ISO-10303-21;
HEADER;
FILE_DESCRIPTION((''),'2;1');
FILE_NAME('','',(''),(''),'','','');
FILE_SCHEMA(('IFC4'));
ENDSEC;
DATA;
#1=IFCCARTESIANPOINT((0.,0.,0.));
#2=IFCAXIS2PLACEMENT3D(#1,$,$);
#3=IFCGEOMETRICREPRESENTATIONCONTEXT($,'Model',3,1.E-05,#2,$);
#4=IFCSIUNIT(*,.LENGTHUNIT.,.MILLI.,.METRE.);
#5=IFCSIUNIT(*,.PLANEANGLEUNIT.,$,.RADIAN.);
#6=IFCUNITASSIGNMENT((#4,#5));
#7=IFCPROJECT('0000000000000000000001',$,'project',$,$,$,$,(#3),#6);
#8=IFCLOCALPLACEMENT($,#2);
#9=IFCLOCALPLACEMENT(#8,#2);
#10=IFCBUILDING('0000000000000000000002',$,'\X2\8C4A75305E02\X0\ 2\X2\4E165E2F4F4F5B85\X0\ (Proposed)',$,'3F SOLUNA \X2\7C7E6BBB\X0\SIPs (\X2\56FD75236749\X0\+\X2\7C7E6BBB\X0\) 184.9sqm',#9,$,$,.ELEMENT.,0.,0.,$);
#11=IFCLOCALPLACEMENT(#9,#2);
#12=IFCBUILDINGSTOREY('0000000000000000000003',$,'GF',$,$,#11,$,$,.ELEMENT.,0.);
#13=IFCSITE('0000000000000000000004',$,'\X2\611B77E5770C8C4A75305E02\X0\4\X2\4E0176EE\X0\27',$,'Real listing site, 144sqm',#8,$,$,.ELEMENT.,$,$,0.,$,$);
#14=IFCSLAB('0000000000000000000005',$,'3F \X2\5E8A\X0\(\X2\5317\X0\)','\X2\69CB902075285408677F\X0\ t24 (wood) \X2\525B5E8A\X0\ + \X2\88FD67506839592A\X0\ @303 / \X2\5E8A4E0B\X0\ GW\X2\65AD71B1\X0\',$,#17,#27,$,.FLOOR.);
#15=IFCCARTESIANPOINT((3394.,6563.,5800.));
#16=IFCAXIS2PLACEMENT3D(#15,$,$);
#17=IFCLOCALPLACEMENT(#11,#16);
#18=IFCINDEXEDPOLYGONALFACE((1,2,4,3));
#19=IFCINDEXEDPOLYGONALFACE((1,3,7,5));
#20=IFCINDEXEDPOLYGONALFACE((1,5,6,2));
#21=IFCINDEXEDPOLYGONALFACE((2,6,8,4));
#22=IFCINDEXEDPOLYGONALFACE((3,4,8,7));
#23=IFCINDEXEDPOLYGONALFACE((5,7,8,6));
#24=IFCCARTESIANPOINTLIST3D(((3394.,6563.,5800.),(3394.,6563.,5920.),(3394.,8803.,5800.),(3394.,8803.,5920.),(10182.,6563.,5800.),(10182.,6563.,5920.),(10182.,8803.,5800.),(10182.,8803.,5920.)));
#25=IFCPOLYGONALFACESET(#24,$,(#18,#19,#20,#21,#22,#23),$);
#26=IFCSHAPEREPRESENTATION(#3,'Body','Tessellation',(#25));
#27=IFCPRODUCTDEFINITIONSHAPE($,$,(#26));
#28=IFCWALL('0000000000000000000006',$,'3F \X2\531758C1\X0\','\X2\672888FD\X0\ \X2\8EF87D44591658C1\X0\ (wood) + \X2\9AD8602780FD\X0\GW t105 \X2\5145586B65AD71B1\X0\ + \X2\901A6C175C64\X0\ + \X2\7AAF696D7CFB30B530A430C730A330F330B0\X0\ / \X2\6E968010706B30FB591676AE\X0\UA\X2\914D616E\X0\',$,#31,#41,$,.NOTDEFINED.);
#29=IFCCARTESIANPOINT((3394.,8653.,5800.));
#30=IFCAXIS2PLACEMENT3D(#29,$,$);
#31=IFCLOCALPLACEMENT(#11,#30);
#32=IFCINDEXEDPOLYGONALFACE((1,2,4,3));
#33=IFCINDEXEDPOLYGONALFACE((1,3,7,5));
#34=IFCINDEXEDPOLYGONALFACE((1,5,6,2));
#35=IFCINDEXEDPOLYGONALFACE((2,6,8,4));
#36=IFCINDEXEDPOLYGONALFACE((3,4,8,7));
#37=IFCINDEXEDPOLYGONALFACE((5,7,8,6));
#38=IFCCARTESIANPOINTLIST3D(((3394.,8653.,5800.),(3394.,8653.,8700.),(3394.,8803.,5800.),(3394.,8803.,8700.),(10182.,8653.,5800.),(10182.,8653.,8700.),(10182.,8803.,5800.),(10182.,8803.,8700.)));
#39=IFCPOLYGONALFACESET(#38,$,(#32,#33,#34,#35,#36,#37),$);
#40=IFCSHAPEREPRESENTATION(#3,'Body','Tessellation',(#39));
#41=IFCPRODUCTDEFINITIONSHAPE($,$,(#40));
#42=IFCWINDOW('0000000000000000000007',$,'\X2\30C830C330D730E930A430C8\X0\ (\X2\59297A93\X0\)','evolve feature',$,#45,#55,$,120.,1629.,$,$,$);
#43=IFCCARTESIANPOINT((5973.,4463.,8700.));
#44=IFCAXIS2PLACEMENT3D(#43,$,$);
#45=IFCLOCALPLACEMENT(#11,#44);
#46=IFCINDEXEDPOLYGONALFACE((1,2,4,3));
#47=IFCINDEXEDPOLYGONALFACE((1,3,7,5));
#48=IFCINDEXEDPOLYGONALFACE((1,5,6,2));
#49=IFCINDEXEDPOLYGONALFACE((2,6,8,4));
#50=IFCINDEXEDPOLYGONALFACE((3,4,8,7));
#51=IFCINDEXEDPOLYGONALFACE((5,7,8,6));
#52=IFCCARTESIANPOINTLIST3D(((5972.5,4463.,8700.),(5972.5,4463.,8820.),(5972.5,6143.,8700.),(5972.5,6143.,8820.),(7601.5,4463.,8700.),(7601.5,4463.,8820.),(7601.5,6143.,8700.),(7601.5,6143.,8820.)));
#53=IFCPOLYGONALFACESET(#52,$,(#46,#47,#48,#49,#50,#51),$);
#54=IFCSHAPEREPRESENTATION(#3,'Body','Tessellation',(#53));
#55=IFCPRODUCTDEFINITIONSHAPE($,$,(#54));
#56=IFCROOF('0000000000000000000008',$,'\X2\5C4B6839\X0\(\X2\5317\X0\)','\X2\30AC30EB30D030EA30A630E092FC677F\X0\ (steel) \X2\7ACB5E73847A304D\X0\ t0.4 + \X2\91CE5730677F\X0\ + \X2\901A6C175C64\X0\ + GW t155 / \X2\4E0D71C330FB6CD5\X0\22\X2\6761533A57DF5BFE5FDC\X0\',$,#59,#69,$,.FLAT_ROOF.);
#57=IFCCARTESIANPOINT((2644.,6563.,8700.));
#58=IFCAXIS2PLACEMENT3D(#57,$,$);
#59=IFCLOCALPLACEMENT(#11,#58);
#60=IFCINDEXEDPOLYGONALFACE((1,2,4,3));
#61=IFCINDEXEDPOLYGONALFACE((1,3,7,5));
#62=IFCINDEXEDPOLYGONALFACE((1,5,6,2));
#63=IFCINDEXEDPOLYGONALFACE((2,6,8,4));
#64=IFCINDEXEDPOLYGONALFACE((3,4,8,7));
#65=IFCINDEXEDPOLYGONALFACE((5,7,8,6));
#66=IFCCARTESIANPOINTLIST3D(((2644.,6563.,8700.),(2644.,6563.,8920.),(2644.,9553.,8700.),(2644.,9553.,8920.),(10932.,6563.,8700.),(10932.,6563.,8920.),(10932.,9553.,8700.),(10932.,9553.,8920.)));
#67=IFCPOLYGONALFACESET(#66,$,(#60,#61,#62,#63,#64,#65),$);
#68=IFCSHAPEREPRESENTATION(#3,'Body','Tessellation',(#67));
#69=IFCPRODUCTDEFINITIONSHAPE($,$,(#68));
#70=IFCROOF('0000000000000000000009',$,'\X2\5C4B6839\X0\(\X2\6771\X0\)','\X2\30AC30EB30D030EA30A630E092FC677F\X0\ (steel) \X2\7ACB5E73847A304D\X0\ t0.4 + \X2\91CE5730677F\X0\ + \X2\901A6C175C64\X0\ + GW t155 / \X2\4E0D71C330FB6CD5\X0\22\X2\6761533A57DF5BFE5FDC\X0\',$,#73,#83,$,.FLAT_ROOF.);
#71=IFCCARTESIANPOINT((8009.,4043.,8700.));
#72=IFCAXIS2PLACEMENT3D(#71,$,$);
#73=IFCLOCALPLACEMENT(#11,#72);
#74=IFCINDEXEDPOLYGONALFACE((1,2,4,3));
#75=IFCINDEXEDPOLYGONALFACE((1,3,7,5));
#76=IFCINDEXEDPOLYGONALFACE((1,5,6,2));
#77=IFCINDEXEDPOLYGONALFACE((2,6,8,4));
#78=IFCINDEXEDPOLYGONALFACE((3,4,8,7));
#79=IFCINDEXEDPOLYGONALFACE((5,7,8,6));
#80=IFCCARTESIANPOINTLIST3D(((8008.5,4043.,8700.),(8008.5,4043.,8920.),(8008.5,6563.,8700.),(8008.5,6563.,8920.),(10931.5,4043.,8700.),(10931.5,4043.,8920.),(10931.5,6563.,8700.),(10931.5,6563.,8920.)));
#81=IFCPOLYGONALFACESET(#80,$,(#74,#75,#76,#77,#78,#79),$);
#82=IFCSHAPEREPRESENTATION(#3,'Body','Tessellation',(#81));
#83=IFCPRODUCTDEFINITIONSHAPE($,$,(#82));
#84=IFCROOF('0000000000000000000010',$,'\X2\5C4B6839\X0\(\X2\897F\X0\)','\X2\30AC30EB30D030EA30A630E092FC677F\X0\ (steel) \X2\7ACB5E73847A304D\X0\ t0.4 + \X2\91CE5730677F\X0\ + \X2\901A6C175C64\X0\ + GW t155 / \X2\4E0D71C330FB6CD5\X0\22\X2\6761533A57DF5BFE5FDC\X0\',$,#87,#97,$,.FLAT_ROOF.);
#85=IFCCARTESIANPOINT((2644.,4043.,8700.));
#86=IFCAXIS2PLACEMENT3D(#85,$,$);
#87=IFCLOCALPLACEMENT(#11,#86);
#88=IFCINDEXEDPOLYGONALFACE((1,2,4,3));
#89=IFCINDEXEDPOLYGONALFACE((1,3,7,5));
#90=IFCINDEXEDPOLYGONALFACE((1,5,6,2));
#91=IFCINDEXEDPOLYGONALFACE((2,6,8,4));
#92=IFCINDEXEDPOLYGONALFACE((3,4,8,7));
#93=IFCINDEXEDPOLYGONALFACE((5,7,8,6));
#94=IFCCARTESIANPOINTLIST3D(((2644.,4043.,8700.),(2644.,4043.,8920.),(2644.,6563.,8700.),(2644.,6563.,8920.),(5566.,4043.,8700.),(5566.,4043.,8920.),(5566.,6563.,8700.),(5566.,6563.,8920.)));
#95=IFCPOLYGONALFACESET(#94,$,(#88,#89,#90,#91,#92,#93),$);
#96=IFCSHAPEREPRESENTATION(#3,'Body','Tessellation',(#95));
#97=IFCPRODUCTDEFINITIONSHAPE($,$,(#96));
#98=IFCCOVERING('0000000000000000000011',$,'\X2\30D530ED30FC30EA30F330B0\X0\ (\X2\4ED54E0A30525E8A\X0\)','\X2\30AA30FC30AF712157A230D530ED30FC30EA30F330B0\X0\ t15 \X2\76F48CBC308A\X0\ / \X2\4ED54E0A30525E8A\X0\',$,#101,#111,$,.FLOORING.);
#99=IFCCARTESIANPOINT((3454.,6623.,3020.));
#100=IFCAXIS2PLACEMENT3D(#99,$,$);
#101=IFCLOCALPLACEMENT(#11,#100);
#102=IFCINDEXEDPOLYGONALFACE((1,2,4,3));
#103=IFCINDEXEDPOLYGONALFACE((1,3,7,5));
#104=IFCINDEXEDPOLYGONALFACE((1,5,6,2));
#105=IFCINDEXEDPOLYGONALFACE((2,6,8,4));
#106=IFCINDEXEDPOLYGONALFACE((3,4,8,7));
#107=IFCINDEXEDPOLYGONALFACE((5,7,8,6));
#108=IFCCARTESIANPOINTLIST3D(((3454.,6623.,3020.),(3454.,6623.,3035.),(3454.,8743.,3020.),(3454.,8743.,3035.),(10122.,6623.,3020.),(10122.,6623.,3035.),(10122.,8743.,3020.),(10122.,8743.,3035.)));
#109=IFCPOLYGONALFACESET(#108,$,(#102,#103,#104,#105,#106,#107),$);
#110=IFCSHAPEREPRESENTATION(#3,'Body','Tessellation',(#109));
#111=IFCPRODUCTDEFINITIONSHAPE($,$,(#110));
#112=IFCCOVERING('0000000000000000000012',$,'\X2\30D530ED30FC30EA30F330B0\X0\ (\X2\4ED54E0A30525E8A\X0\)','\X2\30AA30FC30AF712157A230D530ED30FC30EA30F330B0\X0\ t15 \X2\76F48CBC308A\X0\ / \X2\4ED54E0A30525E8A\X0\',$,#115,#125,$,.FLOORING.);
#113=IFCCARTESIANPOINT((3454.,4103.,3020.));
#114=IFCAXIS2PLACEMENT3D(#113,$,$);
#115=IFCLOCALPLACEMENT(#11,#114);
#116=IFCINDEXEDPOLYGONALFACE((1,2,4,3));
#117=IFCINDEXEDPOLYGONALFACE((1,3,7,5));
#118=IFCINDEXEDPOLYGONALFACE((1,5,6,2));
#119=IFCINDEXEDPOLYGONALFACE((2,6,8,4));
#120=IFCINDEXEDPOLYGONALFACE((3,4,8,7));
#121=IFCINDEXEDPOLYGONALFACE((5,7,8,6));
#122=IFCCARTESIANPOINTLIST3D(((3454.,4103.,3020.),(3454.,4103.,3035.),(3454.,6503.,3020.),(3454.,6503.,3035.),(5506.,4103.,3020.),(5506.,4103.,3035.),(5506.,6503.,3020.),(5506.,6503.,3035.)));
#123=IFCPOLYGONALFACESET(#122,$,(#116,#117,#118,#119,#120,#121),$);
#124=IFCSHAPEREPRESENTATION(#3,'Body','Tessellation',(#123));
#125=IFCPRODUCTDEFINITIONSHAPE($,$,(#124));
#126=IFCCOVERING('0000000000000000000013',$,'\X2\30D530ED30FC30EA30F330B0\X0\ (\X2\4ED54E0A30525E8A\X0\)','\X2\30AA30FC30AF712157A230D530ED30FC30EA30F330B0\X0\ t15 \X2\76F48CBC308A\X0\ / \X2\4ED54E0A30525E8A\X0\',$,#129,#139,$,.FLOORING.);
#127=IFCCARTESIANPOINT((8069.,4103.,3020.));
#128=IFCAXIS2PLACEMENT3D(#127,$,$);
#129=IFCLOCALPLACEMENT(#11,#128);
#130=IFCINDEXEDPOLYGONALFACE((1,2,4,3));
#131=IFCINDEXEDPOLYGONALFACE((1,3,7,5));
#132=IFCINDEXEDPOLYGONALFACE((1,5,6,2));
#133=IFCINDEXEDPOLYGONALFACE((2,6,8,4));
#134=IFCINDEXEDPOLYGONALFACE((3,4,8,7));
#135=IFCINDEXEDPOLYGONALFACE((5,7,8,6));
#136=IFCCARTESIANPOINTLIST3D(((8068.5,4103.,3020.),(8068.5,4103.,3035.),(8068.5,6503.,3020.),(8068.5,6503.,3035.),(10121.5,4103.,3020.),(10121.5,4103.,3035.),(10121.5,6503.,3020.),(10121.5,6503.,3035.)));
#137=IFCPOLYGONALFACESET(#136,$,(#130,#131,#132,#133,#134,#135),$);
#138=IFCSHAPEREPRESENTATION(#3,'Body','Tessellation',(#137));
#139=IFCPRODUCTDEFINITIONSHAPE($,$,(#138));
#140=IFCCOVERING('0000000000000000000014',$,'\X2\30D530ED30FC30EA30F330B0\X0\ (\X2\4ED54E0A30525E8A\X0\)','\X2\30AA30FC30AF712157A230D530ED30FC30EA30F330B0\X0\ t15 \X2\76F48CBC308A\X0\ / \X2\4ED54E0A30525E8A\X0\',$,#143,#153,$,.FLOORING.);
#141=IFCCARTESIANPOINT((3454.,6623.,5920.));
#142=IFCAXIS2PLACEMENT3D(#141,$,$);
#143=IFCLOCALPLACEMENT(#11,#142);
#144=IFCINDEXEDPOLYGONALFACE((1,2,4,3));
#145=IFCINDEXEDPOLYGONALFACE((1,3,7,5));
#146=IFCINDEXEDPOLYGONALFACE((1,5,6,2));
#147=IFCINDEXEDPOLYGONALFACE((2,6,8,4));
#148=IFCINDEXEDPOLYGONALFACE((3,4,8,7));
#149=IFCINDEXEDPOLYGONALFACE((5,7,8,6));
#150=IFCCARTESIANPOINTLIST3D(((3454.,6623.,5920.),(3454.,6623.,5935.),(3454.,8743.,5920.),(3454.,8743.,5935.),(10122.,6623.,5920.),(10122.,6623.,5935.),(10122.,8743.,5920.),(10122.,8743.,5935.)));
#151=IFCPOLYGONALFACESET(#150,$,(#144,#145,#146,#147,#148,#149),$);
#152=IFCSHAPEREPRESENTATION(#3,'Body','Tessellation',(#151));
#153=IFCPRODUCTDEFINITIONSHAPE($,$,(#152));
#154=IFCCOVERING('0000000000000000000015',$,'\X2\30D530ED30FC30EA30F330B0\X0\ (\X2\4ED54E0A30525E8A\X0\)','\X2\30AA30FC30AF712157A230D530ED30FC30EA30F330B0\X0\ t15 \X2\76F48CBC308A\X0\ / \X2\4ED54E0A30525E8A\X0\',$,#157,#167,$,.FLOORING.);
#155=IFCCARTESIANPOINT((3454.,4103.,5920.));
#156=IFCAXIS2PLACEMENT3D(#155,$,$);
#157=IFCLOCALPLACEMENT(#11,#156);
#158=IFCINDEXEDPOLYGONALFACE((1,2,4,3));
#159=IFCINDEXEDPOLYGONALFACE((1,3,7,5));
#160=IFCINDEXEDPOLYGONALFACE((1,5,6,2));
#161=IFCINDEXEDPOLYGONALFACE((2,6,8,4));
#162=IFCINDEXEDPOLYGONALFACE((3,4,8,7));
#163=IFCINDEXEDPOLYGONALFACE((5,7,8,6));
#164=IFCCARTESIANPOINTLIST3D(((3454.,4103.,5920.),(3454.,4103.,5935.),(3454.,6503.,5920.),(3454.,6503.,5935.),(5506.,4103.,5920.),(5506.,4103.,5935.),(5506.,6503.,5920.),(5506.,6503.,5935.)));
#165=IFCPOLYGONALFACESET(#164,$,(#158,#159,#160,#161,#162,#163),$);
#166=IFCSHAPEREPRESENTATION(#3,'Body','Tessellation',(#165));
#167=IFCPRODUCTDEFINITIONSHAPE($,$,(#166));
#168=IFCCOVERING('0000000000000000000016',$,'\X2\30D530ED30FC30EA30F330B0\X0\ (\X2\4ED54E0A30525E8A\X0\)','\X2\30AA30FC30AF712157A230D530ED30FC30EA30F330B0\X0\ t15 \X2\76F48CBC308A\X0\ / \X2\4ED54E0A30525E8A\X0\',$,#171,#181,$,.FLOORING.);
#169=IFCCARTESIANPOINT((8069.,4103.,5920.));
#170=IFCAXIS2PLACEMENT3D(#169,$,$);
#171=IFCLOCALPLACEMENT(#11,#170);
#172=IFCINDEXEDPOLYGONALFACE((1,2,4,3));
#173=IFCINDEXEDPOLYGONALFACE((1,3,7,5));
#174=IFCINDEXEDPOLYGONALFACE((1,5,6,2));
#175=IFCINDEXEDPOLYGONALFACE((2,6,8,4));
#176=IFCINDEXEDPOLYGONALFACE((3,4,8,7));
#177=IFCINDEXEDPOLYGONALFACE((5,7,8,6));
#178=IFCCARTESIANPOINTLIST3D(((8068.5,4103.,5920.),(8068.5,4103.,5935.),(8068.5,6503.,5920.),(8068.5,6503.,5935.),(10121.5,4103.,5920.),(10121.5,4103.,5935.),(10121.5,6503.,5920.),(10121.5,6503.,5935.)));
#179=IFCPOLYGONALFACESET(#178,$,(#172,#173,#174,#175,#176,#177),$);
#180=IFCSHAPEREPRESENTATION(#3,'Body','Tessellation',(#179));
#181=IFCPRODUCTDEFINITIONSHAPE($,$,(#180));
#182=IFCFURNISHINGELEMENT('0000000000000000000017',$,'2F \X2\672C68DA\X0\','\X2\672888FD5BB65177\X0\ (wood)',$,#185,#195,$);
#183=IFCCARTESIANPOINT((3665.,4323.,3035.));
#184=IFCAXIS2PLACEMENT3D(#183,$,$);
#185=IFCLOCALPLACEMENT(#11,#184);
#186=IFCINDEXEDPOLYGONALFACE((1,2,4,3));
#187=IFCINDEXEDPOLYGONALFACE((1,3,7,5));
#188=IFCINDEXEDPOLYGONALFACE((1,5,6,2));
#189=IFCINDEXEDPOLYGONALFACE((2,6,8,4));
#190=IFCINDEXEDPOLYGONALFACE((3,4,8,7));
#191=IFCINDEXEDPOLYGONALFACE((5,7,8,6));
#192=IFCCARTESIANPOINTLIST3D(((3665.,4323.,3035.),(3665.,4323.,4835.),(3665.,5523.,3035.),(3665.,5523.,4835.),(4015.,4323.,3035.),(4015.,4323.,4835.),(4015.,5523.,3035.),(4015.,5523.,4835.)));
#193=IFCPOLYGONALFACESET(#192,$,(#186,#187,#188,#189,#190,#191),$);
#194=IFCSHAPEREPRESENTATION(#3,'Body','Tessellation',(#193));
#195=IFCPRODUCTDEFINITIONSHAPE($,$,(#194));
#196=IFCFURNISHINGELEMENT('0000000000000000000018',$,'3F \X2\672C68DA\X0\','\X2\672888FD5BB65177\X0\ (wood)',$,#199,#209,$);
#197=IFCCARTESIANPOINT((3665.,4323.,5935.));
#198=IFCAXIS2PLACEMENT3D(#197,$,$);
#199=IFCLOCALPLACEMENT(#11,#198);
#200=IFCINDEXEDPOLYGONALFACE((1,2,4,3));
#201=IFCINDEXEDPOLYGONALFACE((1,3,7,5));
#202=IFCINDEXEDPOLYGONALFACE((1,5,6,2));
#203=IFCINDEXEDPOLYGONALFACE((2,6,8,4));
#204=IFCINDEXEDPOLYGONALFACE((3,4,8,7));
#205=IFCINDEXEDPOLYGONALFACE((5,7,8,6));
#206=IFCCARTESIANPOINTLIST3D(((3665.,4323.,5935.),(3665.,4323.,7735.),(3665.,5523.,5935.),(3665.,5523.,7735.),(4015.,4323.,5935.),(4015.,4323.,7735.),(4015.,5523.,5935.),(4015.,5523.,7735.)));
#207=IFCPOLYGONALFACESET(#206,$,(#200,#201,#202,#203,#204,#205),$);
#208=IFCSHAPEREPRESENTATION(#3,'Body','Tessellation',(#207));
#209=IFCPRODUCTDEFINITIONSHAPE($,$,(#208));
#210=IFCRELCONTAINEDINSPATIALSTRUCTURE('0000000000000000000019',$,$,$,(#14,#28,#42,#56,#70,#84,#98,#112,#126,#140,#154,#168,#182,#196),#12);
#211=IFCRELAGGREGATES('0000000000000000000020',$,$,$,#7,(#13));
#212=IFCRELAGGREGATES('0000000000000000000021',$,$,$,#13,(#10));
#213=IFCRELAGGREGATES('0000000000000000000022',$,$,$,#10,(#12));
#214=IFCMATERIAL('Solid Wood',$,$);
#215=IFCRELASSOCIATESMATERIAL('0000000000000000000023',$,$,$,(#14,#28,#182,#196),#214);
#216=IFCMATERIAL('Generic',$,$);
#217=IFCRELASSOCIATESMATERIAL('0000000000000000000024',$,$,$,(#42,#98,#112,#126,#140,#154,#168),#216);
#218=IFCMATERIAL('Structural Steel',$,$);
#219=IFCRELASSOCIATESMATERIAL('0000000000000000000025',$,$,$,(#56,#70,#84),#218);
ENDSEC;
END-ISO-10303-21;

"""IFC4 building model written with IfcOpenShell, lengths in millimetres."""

from ifc_helpers import new_model, si_unit, frame, frame_2d, origin, place, context, project, spatial, rectangle, extrude, material, element, save


model = new_model("IFC4")

# Units and contexts
model_context = context("Model", 3, precision=1e-05, world=origin())
ifc_project = project(units=[si_unit("LENGTHUNIT", "METRE", prefix="MILLI"), si_unit("PLANEANGLEUNIT", "RADIAN")], contexts=[model_context])

# Site, building, storey
site_placement = place(None, origin())
site = spatial("IfcSite", under=ifc_project, at=site_placement, Name="愛知県豊田市4丁目27", ObjectType="Real listing site, 144sqm", CompositionType="ELEMENT", RefElevation=0.0)
building_placement = place(site_placement, origin())
building = spatial("IfcBuilding", under=site, at=building_placement, Name="豊田市 2世帯住宅 (Proposed)", ObjectType="3F SOLUNA 籾殻SIPs (国産杉+籾殻) 184.9sqm", CompositionType="ELEMENT", ElevationOfRefHeight=0.0, ElevationOfTerrain=0.0)
storey_placement = place(building_placement, origin())
storey = spatial("IfcBuildingStorey", under=building, at=storey_placement, Name="GF", CompositionType="ELEMENT", Elevation=0.0)

# Slab
ifc_material_1 = material(Name="Solid Wood")
slab_placement = place(storey_placement, frame((3394.0, 6563.0, 5800.0)))
element("IfcSlab", 1, at=slab_placement, inside=storey, material=ifc_material_1, Name="3F 床(北)", Description="構造用合板 t24 (wood) 剛床 + 製材根太 @303 / 床下 GW断熱", PredefinedType="FLOOR", context=model_context, shape_type="SweptSolid", body=[
    extrude(rectangle(XDim=6788.0, YDim=2240.0, at=frame_2d((3394.0, 1120.0))), frame((3394.0, 6563.0, 5800.0)), (0.0, 0.0, 1.0), 120.0),
])

# Wall
wall_1_placement = place(storey_placement, frame((3394.0, 8653.0, 5800.0)))
element("IfcWall", 2, at=wall_1_placement, inside=storey, material=ifc_material_1, Name="3F 北壁", Description="木製 軸組外壁 (wood) + 高性能GW t105 充填断熱 + 通気層 + 窯業系サイディング / 準耐火・外皮UA配慮", PredefinedType="NOTDEFINED", context=model_context, shape_type="SweptSolid", body=[
    extrude(rectangle(XDim=6788.0, YDim=150.0, at=frame_2d((3394.0, 75.0))), frame((3394.0, 8653.0, 5800.0)), (0.0, 0.0, 1.0), 2900.0),
])

# Window
ifc_material_2 = material(Name="Generic")
window_1_placement = place(storey_placement, frame((5973.0, 4463.0, 8700.0)))
element("IfcWindow", 3, at=window_1_placement, inside=storey, material=ifc_material_2, Name="トップライト (天窓)", Description="evolve feature", OverallHeight=120.0, OverallWidth=1629.0, context=model_context, shape_type="SweptSolid", body=[
    extrude(rectangle(XDim=1629.0, YDim=1680.0, at=frame_2d((814.0, 840.0))), frame((5973.0, 4463.0, 8700.0)), (0.0, 0.0, 1.0), 120.0),
])

# Roofs
ifc_material_3 = material(Name="Structural Steel")
roof_1_placement = place(storey_placement, frame((2644.0, 6563.0, 8700.0)))
element("IfcRoof", 4, at=roof_1_placement, inside=storey, material=ifc_material_3, Name="屋根(北)", Description="ガルバリウム鋼板 (steel) 立平葺き t0.4 + 野地板 + 通気層 + GW t155 / 不燃・法22条区域対応", PredefinedType="FLAT_ROOF", context=model_context, shape_type="SweptSolid", body=[
    extrude(rectangle(XDim=8288.0, YDim=2990.0, at=frame_2d((4144.0, 1495.0))), frame((2644.0, 6563.0, 8700.0)), (0.0, 0.0, 1.0), 220.0),
])
roof_2_placement = place(storey_placement, frame((8009.0, 4043.0, 8700.0)))
element("IfcRoof", 5, at=roof_2_placement, inside=storey, material=ifc_material_3, Name="屋根(東)", Description="ガルバリウム鋼板 (steel) 立平葺き t0.4 + 野地板 + 通気層 + GW t155 / 不燃・法22条区域対応", PredefinedType="FLAT_ROOF", context=model_context, shape_type="SweptSolid", body=[
    extrude(rectangle(XDim=2923.0, YDim=2520.0, at=frame_2d((1461.0, 1260.0))), frame((8009.0, 4043.0, 8700.0)), (0.0, 0.0, 1.0), 220.0),
])
roof_3_placement = place(storey_placement, frame((2644.0, 4043.0, 8700.0)))
element("IfcRoof", 6, at=roof_3_placement, inside=storey, material=ifc_material_3, Name="屋根(西)", Description="ガルバリウム鋼板 (steel) 立平葺き t0.4 + 野地板 + 通気層 + GW t155 / 不燃・法22条区域対応", PredefinedType="FLAT_ROOF", context=model_context, shape_type="SweptSolid", body=[
    extrude(rectangle(XDim=2922.0, YDim=2520.0, at=frame_2d((1461.0, 1260.0))), frame((2644.0, 4043.0, 8700.0)), (0.0, 0.0, 1.0), 220.0),
])

# Coverings
covering_1_placement = place(storey_placement, frame((3454.0, 6623.0, 3020.0)))
element("IfcCovering", 7, at=covering_1_placement, inside=storey, material=ifc_material_2, Name="フローリング (仕上げ床)", Description="オーク無垢フローリング t15 直貼り / 仕上げ床", PredefinedType="FLOORING", context=model_context, shape_type="SweptSolid", body=[
    extrude(rectangle(XDim=6668.0, YDim=2120.0, at=frame_2d((3334.0, 1060.0))), frame((3454.0, 6623.0, 3020.0)), (0.0, 0.0, 1.0), 15.0),
])
covering_2_placement = place(storey_placement, frame((3454.0, 4103.0, 3020.0)))
element("IfcCovering", 8, at=covering_2_placement, inside=storey, material=ifc_material_2, Name="フローリング (仕上げ床)", Description="オーク無垢フローリング t15 直貼り / 仕上げ床", PredefinedType="FLOORING", context=model_context, shape_type="SweptSolid", body=[
    extrude(rectangle(XDim=2052.0, YDim=2400.0, at=frame_2d((1026.0, 1200.0))), frame((3454.0, 4103.0, 3020.0)), (0.0, 0.0, 1.0), 15.0),
])
covering_3_placement = place(storey_placement, frame((8069.0, 4103.0, 3020.0)))
element("IfcCovering", 9, at=covering_3_placement, inside=storey, material=ifc_material_2, Name="フローリング (仕上げ床)", Description="オーク無垢フローリング t15 直貼り / 仕上げ床", PredefinedType="FLOORING", context=model_context, shape_type="SweptSolid", body=[
    extrude(rectangle(XDim=2053.0, YDim=2400.0, at=frame_2d((1026.0, 1200.0))), frame((8069.0, 4103.0, 3020.0)), (0.0, 0.0, 1.0), 15.0),
])
covering_4_placement = place(storey_placement, frame((3454.0, 6623.0, 5920.0)))
element("IfcCovering", 10, at=covering_4_placement, inside=storey, material=ifc_material_2, Name="フローリング (仕上げ床)", Description="オーク無垢フローリング t15 直貼り / 仕上げ床", PredefinedType="FLOORING", context=model_context, shape_type="SweptSolid", body=[
    extrude(rectangle(XDim=6668.0, YDim=2120.0, at=frame_2d((3334.0, 1060.0))), frame((3454.0, 6623.0, 5920.0)), (0.0, 0.0, 1.0), 15.0),
])
covering_5_placement = place(storey_placement, frame((3454.0, 4103.0, 5920.0)))
element("IfcCovering", 11, at=covering_5_placement, inside=storey, material=ifc_material_2, Name="フローリング (仕上げ床)", Description="オーク無垢フローリング t15 直貼り / 仕上げ床", PredefinedType="FLOORING", context=model_context, shape_type="SweptSolid", body=[
    extrude(rectangle(XDim=2052.0, YDim=2400.0, at=frame_2d((1026.0, 1200.0))), frame((3454.0, 4103.0, 5920.0)), (0.0, 0.0, 1.0), 15.0),
])
covering_6_placement = place(storey_placement, frame((8069.0, 4103.0, 5920.0)))
element("IfcCovering", 12, at=covering_6_placement, inside=storey, material=ifc_material_2, Name="フローリング (仕上げ床)", Description="オーク無垢フローリング t15 直貼り / 仕上げ床", PredefinedType="FLOORING", context=model_context, shape_type="SweptSolid", body=[
    extrude(rectangle(XDim=2053.0, YDim=2400.0, at=frame_2d((1026.0, 1200.0))), frame((8069.0, 4103.0, 5920.0)), (0.0, 0.0, 1.0), 15.0),
])

# Furnishing elements
furnishing_1_placement = place(storey_placement, frame((3665.0, 4323.0, 3035.0)))
element("IfcFurnishingElement", 13, at=furnishing_1_placement, inside=storey, material=ifc_material_1, Name="2F 本棚", Description="木製家具 (wood)", context=model_context, shape_type="SweptSolid", body=[
    extrude(rectangle(XDim=350.0, YDim=1200.0, at=frame_2d((175.0, 600.0))), frame((3665.0, 4323.0, 3035.0)), (0.0, 0.0, 1.0), 1800.0),
])
furnishing_2_placement = place(storey_placement, frame((3665.0, 4323.0, 5935.0)))
element("IfcFurnishingElement", 14, at=furnishing_2_placement, inside=storey, material=ifc_material_1, Name="3F 本棚", Description="木製家具 (wood)", context=model_context, shape_type="SweptSolid", body=[
    extrude(rectangle(XDim=350.0, YDim=1200.0, at=frame_2d((175.0, 600.0))), frame((3665.0, 4323.0, 5935.0)), (0.0, 0.0, 1.0), 1800.0),
])

save(model, "model.ifc")
